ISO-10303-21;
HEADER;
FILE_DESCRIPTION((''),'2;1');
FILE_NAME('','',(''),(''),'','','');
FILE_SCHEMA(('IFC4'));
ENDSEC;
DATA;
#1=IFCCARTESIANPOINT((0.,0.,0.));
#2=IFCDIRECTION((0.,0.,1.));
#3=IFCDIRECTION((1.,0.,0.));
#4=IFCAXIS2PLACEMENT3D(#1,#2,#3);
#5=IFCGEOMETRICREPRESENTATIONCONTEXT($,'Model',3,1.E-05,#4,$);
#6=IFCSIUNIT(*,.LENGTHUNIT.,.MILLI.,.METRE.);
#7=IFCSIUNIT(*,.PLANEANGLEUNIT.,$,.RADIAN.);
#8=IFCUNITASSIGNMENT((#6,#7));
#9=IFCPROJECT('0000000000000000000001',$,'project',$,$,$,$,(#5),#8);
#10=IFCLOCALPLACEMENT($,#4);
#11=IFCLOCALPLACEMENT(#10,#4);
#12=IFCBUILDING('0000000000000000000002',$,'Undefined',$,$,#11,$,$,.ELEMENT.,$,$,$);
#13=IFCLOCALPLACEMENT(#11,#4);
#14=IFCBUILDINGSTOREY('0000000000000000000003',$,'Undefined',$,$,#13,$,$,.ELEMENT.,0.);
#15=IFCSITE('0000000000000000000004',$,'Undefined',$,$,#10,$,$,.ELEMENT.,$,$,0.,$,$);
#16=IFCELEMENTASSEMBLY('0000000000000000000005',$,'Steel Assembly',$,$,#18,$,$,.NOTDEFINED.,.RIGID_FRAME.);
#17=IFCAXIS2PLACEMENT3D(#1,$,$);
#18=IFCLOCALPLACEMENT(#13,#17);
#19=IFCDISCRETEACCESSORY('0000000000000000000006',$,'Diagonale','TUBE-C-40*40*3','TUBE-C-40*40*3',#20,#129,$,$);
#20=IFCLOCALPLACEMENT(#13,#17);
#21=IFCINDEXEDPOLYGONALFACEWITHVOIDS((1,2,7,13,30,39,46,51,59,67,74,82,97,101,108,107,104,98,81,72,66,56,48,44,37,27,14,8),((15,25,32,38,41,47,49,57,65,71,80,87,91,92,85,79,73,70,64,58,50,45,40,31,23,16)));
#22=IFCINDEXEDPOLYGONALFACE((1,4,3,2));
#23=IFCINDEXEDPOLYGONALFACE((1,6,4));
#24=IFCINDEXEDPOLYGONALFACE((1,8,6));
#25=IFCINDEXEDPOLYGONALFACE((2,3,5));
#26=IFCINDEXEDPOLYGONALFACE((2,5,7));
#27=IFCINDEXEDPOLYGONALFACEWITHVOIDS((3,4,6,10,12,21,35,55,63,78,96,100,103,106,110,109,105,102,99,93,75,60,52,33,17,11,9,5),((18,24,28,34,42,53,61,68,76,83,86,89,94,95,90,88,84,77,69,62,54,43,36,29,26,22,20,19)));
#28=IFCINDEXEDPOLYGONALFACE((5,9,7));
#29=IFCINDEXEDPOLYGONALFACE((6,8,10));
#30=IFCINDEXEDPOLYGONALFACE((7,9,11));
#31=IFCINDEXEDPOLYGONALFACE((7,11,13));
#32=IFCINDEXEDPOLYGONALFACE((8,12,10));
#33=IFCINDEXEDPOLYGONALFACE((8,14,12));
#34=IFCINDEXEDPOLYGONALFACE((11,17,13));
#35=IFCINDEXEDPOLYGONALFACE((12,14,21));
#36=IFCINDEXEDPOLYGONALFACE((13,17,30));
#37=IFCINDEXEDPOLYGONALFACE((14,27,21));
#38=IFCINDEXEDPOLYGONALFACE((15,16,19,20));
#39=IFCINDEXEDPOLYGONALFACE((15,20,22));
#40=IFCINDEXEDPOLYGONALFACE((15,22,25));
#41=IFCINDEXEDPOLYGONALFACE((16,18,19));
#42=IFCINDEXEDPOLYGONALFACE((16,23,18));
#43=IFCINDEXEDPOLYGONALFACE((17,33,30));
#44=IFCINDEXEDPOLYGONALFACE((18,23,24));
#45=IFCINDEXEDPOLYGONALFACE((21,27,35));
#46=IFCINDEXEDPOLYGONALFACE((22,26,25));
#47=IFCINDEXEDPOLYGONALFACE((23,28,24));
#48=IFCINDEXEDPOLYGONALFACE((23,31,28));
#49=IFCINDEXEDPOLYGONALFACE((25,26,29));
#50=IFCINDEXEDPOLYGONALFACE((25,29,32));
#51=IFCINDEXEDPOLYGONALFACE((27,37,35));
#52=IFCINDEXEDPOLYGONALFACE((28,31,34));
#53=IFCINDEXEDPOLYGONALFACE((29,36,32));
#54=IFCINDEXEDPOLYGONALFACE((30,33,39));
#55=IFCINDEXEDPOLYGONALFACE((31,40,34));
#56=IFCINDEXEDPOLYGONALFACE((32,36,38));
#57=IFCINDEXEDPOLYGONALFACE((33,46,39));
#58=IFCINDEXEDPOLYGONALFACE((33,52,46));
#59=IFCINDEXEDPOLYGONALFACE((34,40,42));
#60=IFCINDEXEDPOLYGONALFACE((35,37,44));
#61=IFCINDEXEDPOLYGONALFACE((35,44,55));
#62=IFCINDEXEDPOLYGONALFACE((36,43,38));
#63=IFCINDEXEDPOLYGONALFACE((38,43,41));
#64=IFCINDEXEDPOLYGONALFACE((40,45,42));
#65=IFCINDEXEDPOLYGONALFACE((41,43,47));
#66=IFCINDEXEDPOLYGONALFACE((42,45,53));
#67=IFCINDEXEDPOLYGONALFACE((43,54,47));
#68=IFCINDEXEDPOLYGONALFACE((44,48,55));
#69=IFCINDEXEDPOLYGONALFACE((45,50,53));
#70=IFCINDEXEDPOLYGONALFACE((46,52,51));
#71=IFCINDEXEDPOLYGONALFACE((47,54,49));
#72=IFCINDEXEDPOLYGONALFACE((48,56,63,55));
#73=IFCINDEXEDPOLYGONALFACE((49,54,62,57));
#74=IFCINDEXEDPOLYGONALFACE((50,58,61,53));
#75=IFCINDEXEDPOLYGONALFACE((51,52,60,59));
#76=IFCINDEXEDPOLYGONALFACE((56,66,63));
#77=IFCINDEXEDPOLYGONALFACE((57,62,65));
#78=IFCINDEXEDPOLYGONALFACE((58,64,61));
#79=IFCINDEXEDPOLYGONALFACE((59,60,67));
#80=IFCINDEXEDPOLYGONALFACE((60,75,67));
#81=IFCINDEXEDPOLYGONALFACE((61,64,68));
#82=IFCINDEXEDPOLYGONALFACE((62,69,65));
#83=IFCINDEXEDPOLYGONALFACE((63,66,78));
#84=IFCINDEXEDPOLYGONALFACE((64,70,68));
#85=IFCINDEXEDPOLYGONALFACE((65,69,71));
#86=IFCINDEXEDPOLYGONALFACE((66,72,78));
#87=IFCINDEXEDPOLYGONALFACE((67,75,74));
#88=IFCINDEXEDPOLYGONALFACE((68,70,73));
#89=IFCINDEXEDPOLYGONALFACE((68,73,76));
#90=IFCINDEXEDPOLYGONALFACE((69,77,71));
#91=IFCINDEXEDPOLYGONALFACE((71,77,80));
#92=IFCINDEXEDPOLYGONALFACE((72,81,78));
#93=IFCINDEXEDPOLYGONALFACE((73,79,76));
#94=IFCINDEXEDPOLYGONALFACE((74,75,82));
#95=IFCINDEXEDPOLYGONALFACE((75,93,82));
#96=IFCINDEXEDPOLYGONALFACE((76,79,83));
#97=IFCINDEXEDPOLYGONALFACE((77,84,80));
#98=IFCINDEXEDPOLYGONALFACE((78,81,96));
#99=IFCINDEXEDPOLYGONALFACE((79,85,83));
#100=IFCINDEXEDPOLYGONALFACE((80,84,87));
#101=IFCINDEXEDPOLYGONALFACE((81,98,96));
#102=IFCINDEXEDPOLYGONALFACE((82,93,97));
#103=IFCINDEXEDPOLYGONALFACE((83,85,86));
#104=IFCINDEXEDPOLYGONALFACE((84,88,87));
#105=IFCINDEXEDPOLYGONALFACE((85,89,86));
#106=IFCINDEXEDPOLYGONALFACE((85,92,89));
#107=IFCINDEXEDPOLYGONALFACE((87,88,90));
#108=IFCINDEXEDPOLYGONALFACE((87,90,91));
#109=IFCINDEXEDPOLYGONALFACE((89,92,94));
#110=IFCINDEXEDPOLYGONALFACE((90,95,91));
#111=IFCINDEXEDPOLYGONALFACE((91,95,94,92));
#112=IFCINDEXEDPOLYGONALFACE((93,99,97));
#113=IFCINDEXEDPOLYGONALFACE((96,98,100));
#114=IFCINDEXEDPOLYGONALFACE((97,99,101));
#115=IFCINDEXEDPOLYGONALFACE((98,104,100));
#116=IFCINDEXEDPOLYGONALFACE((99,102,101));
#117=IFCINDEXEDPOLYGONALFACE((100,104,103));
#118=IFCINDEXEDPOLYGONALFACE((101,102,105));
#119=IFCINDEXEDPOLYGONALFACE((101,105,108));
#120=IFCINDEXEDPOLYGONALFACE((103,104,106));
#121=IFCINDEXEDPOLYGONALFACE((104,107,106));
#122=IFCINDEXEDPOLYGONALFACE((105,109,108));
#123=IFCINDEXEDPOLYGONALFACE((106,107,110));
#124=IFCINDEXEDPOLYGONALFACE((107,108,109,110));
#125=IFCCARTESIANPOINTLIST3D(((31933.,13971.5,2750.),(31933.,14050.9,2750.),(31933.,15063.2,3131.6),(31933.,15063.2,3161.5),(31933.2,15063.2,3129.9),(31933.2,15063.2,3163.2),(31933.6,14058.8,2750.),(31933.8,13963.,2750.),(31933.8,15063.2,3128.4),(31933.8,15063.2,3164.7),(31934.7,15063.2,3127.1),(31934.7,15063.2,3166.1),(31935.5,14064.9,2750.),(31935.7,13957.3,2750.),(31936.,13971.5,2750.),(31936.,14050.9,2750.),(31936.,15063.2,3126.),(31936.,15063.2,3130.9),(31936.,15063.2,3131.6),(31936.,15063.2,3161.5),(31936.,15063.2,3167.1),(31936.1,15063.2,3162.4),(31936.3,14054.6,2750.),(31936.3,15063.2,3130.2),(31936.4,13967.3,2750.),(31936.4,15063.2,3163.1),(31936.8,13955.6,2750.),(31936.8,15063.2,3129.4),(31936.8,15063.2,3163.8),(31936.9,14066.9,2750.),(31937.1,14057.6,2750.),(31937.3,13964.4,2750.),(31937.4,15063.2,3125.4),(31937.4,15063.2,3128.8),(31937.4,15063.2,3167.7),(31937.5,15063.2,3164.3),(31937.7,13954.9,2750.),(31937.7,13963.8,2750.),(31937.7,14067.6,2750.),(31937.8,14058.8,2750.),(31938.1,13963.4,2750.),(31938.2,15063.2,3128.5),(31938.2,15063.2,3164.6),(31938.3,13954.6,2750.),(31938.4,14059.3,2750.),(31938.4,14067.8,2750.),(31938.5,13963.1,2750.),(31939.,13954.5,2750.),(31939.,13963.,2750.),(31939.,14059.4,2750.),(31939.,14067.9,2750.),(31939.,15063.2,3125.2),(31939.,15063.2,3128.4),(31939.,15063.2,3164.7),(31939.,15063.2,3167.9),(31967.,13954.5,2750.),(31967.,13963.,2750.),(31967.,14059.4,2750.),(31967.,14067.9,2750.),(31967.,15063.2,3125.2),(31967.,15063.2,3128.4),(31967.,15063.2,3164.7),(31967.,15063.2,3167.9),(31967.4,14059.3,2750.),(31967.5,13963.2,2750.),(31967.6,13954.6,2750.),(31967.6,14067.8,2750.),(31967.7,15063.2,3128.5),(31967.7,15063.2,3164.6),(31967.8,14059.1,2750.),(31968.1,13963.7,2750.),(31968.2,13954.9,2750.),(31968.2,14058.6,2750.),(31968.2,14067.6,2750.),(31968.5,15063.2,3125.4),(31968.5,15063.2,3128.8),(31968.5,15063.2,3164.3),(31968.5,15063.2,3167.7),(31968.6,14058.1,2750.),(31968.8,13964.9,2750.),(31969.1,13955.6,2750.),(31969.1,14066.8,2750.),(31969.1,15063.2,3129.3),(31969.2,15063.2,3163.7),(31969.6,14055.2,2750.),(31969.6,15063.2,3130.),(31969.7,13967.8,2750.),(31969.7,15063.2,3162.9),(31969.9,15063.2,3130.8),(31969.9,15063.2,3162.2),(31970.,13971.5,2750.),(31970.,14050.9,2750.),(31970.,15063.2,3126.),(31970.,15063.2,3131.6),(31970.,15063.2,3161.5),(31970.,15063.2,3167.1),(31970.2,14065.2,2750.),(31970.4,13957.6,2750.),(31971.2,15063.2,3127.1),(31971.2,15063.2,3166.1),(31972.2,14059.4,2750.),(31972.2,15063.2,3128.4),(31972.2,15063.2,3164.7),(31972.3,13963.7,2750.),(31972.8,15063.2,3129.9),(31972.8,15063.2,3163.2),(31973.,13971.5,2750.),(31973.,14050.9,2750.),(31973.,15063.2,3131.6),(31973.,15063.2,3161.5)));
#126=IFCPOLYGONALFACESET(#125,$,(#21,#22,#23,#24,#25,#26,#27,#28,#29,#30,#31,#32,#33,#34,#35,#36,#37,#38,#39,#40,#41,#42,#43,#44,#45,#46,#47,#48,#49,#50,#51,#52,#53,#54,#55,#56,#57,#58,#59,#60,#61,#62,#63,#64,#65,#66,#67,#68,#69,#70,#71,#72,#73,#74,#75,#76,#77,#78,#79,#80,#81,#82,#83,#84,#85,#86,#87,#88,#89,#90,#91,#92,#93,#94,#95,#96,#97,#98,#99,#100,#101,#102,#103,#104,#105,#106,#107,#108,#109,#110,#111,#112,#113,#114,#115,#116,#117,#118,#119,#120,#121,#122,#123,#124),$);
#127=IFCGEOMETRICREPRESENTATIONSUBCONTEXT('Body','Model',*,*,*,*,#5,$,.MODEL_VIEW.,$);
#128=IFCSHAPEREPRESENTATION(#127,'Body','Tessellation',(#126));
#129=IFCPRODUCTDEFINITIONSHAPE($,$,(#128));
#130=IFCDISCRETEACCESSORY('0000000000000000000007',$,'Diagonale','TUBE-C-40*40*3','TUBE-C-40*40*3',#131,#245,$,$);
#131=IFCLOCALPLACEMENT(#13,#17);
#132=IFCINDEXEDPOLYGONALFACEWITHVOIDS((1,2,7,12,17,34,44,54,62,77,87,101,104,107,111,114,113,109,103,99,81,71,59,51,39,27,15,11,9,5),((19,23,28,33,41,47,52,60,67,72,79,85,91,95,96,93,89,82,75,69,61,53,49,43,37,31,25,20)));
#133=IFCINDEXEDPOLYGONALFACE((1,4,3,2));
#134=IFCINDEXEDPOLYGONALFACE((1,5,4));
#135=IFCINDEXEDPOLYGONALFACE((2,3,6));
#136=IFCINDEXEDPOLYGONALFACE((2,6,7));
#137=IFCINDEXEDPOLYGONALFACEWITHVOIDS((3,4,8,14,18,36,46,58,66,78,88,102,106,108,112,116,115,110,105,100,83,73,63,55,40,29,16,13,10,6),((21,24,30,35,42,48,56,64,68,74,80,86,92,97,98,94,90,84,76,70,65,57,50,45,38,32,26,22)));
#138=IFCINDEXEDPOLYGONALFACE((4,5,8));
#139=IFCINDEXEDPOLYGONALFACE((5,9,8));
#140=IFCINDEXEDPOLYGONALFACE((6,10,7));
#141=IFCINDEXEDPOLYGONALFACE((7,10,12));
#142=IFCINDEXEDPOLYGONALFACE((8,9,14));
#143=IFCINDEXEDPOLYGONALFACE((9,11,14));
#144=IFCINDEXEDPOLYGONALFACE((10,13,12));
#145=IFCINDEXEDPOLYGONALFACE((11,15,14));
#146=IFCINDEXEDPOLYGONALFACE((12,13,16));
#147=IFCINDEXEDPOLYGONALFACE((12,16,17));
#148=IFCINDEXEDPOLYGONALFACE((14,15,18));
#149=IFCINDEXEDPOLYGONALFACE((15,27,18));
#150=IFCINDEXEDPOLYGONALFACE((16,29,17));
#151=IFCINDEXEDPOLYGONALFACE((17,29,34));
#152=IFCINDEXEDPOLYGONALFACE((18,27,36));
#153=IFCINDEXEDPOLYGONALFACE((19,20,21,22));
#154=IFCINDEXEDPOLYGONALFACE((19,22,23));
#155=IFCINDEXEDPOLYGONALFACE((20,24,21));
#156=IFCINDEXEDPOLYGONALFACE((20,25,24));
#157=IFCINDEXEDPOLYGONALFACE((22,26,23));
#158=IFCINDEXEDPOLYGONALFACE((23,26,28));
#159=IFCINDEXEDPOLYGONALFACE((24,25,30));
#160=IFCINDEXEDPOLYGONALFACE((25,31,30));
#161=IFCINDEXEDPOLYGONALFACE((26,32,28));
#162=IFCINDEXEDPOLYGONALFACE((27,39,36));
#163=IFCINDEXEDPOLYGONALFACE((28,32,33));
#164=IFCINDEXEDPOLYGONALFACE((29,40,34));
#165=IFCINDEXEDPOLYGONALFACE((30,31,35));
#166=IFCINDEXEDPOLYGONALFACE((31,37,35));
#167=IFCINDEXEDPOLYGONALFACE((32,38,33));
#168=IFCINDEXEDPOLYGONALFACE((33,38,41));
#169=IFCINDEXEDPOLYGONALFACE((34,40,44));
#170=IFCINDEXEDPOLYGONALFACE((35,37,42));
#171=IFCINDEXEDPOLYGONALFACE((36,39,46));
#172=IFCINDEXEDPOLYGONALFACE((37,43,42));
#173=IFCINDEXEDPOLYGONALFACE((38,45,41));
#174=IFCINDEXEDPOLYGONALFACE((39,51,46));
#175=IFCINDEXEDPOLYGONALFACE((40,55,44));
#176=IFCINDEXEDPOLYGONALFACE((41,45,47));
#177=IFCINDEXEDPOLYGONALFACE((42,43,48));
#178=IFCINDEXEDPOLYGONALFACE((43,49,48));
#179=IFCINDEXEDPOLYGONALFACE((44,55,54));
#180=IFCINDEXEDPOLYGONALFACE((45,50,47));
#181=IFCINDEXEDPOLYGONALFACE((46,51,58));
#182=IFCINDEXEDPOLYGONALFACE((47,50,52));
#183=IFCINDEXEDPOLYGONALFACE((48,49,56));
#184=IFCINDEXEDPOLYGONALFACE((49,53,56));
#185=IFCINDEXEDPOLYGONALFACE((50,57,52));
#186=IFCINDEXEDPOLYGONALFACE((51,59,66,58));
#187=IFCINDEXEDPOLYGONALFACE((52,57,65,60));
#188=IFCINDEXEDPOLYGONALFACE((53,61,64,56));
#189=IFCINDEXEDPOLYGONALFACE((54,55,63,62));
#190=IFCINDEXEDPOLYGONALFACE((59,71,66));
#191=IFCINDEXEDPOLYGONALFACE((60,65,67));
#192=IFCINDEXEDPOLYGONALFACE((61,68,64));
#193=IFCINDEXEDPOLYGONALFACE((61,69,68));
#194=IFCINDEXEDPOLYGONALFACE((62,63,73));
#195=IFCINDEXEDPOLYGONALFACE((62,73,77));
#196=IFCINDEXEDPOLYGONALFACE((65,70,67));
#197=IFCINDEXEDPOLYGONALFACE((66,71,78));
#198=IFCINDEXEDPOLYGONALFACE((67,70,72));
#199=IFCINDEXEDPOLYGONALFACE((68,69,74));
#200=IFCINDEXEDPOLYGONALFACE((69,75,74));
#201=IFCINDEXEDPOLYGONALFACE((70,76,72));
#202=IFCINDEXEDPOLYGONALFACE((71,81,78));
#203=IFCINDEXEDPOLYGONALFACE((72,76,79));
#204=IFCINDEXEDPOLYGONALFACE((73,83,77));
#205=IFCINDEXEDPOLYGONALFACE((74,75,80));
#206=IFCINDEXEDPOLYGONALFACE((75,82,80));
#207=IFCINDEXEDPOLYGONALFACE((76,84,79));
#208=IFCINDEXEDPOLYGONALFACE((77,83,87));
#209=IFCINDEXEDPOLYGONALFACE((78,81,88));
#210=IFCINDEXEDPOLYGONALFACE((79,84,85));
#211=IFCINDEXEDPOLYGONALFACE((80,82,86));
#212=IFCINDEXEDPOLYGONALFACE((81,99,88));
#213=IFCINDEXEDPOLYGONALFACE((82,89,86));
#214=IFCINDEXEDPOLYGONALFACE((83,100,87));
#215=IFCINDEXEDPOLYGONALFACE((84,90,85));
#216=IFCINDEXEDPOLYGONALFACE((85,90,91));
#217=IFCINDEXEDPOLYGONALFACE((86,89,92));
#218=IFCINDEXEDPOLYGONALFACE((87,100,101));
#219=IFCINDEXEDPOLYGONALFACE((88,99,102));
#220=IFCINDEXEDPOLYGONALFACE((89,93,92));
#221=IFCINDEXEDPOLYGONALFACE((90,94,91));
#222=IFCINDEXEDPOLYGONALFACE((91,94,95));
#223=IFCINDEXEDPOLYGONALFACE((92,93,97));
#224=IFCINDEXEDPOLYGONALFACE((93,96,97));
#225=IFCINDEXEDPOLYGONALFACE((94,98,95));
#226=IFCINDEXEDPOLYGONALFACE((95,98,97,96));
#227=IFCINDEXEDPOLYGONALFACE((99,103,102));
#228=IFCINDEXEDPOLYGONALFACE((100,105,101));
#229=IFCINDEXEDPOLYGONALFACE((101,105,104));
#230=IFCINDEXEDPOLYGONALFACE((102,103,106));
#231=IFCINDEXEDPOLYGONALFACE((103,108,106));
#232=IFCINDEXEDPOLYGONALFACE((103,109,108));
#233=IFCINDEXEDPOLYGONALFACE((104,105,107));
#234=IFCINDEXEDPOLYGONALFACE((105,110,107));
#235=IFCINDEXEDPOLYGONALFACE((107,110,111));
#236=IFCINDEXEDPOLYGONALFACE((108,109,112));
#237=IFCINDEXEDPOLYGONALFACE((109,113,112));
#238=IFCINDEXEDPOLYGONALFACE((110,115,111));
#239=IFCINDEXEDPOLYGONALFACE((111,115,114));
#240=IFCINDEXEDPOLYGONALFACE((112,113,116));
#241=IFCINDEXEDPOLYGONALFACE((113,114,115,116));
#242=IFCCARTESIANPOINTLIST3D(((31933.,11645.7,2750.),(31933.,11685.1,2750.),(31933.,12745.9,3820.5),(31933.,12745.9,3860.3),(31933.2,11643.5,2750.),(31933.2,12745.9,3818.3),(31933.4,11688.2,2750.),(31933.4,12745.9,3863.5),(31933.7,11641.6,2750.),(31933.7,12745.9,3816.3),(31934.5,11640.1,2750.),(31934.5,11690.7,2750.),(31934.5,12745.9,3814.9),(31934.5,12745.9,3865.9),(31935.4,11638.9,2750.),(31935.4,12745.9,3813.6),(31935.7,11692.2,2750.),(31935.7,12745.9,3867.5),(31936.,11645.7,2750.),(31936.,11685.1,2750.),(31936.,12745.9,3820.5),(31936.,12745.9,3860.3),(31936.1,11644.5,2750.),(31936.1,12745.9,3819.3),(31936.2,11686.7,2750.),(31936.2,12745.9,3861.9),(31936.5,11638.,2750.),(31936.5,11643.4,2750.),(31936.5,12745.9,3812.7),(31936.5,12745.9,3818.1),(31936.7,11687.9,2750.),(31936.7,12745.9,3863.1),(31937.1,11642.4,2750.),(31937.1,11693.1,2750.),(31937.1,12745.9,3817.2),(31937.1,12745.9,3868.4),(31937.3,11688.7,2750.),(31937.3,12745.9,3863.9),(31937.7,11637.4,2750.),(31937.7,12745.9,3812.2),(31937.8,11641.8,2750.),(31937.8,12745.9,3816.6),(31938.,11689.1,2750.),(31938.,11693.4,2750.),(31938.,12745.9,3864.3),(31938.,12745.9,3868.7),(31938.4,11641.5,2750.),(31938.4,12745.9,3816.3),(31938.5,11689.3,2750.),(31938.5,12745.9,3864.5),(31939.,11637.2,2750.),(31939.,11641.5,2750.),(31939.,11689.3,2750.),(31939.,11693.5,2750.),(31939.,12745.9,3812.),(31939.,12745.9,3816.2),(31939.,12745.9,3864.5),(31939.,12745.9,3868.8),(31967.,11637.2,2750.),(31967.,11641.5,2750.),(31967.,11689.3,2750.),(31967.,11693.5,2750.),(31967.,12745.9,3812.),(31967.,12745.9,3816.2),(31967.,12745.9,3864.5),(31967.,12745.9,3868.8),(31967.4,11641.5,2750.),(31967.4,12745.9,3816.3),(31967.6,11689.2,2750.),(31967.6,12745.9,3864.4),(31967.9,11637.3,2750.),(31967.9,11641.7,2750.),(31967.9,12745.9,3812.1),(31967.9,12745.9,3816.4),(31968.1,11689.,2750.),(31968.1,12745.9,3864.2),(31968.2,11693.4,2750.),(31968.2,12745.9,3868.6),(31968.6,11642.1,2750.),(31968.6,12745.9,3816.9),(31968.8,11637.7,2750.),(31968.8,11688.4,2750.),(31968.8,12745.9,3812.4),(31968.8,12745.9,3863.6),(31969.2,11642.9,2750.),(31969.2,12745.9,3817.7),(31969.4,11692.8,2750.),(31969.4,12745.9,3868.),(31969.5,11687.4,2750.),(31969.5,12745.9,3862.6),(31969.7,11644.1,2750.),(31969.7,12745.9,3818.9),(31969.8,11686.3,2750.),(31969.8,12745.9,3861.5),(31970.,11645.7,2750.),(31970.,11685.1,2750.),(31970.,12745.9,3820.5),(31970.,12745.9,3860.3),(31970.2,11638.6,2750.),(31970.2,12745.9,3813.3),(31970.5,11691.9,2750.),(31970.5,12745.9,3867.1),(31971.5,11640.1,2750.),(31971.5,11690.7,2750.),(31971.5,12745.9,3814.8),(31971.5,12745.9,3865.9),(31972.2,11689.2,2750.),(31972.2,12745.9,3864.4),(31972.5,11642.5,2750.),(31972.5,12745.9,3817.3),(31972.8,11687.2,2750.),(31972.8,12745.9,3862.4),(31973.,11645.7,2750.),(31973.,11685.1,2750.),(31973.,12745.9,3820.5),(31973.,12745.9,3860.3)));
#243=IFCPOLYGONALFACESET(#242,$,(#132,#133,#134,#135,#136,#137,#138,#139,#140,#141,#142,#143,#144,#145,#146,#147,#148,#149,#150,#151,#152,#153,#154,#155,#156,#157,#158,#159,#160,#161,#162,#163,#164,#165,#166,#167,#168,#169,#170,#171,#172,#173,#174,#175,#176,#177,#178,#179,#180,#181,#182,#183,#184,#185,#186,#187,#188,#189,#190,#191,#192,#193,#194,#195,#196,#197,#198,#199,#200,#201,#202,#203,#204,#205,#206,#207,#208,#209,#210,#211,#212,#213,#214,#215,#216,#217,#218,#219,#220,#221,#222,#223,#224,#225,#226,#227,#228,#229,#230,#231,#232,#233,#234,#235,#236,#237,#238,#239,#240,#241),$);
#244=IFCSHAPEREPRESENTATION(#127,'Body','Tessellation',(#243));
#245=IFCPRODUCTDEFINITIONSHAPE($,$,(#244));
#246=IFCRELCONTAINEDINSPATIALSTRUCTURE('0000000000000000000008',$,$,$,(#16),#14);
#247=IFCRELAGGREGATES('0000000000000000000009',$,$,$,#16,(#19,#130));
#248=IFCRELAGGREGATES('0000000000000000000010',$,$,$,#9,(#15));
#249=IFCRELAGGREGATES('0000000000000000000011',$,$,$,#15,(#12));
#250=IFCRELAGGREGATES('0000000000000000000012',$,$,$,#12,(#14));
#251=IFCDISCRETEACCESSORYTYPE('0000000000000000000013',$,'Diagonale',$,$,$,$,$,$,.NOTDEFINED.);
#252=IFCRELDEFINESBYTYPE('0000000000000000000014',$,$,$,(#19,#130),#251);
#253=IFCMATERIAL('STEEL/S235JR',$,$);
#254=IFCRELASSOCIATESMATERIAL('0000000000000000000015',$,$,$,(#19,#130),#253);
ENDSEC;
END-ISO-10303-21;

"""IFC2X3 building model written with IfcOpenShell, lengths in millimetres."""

from ifc_helpers import new_model, si_unit, frame, origin_with_axes, origin_2d_with_axis, place, context, subcontext, project, spatial, hollow_rectangle, extrude, clip, halfspace, material, type_object, element, aggregate, save


model = new_model("IFC2X3")

# Units and contexts
model_context = context("Model", 3, precision=1e-05, world=origin_with_axes())
body_context = subcontext(model_context, "Body", "Model", "MODEL_VIEW")
ifc_project = project(units=[si_unit("LENGTHUNIT", "METRE", prefix="MILLI"), si_unit("PLANEANGLEUNIT", "RADIAN")], contexts=[model_context])

# Site, building, storey
site_placement = place(None, origin_with_axes())
site = spatial("IfcSite", under=ifc_project, at=site_placement, Name="Undefined", CompositionType="ELEMENT", RefElevation=0.0)
building_placement = place(site_placement, origin_with_axes())
building = spatial("IfcBuilding", under=site, at=building_placement, Name="Undefined", CompositionType="ELEMENT")
storey_placement = place(building_placement, origin_with_axes())
storey = spatial("IfcBuildingStorey", under=building, at=storey_placement, Name="Undefined", CompositionType="ELEMENT", Elevation=0.0)

# Element assembly, discrete accessories
ifc_material_1 = material(Name="STEEL/S235JR")
discrete_accessory_type_1 = type_object("IfcDiscreteAccessoryType", Name="Diagonale")
assembly_1_placement = place(storey_placement, origin_with_axes())
assembly_1 = element("IfcElementAssembly", 1, at=assembly_1_placement, inside=storey, Name="Steel Assembly", AssemblyPlace="NOTDEFINED", PredefinedType="RIGID_FRAME")
discrete_accessory_1_placement = place(assembly_1_placement, frame((31953.0, 13961.6, 2731.3), z_axis=(0.0, -0.352745, 0.93572), x_axis=(0.0, 0.93572, 0.352745)))
discrete_accessory_1 = element("IfcDiscreteAccessory", 2, at=discrete_accessory_1_placement, type_object=discrete_accessory_type_1, material=ifc_material_1, Name="Diagonale", Description="TUBE-C-40*40*3", ObjectType="TUBE-C-40*40*3", context=body_context, shape_type="Clipping", body=[
    clip(clip(extrude(hollow_rectangle(XDim=40.0, YDim=40.0, WallThickness=3.0, InnerFilletRadius=3.0, OuterFilletRadius=6.0, at=origin_2d_with_axis()), frame((1238.5, 0.0, 0.0), z_axis=(-1.0, 0.0, 0.0), x_axis=(0.0, -1.0, 0.0)), (0.0, 0.0, 1.0), 1246.6), halfspace(frame((1146.9, 0.0, -80.5), z_axis=(0.93572, 0.0, -0.352745), x_axis=(0.0, -1.0, 0.0)), False)), halfspace(frame((172.4, 0.0, -45.0), z_axis=(0.352745, 0.0, 0.93572), x_axis=(0.0, -1.0, 0.0)), True)),
])
discrete_accessory_2_placement = place(assembly_1_placement, frame((31953.0, 11651.4, 2735.9), z_axis=(0.0, -0.710321, 0.703878), x_axis=(0.0, 0.703878, 0.710321)))
discrete_accessory_2 = element("IfcDiscreteAccessory", 3, at=discrete_accessory_2_placement, type_object=discrete_accessory_type_1, material=ifc_material_1, Name="Diagonale", Description="TUBE-C-40*40*3", ObjectType="TUBE-C-40*40*3", context=body_context, shape_type="Clipping", body=[
    clip(clip(extrude(hollow_rectangle(XDim=40.0, YDim=40.0, WallThickness=3.0, InnerFilletRadius=3.0, OuterFilletRadius=6.0, at=origin_2d_with_axis()), frame((1595.3, 0.0, 0.0), z_axis=(-1.0, 0.0, 0.0), x_axis=(0.0, -1.0, 0.0)), (0.0, 0.0, 1.0), 1615.9), halfspace(frame((1512.1, 0.0, -42.4), z_axis=(0.703878, 0.0, -0.710321), x_axis=(0.0, -1.0, 0.0)), False)), halfspace(frame((21.0, 0.0, -1.2), z_axis=(-0.710321, 0.0, -0.703878), x_axis=(0.0, -1.0, 0.0)), False)),
])
aggregate(assembly_1, [discrete_accessory_1, discrete_accessory_2])

save(model, "model.ifc")
